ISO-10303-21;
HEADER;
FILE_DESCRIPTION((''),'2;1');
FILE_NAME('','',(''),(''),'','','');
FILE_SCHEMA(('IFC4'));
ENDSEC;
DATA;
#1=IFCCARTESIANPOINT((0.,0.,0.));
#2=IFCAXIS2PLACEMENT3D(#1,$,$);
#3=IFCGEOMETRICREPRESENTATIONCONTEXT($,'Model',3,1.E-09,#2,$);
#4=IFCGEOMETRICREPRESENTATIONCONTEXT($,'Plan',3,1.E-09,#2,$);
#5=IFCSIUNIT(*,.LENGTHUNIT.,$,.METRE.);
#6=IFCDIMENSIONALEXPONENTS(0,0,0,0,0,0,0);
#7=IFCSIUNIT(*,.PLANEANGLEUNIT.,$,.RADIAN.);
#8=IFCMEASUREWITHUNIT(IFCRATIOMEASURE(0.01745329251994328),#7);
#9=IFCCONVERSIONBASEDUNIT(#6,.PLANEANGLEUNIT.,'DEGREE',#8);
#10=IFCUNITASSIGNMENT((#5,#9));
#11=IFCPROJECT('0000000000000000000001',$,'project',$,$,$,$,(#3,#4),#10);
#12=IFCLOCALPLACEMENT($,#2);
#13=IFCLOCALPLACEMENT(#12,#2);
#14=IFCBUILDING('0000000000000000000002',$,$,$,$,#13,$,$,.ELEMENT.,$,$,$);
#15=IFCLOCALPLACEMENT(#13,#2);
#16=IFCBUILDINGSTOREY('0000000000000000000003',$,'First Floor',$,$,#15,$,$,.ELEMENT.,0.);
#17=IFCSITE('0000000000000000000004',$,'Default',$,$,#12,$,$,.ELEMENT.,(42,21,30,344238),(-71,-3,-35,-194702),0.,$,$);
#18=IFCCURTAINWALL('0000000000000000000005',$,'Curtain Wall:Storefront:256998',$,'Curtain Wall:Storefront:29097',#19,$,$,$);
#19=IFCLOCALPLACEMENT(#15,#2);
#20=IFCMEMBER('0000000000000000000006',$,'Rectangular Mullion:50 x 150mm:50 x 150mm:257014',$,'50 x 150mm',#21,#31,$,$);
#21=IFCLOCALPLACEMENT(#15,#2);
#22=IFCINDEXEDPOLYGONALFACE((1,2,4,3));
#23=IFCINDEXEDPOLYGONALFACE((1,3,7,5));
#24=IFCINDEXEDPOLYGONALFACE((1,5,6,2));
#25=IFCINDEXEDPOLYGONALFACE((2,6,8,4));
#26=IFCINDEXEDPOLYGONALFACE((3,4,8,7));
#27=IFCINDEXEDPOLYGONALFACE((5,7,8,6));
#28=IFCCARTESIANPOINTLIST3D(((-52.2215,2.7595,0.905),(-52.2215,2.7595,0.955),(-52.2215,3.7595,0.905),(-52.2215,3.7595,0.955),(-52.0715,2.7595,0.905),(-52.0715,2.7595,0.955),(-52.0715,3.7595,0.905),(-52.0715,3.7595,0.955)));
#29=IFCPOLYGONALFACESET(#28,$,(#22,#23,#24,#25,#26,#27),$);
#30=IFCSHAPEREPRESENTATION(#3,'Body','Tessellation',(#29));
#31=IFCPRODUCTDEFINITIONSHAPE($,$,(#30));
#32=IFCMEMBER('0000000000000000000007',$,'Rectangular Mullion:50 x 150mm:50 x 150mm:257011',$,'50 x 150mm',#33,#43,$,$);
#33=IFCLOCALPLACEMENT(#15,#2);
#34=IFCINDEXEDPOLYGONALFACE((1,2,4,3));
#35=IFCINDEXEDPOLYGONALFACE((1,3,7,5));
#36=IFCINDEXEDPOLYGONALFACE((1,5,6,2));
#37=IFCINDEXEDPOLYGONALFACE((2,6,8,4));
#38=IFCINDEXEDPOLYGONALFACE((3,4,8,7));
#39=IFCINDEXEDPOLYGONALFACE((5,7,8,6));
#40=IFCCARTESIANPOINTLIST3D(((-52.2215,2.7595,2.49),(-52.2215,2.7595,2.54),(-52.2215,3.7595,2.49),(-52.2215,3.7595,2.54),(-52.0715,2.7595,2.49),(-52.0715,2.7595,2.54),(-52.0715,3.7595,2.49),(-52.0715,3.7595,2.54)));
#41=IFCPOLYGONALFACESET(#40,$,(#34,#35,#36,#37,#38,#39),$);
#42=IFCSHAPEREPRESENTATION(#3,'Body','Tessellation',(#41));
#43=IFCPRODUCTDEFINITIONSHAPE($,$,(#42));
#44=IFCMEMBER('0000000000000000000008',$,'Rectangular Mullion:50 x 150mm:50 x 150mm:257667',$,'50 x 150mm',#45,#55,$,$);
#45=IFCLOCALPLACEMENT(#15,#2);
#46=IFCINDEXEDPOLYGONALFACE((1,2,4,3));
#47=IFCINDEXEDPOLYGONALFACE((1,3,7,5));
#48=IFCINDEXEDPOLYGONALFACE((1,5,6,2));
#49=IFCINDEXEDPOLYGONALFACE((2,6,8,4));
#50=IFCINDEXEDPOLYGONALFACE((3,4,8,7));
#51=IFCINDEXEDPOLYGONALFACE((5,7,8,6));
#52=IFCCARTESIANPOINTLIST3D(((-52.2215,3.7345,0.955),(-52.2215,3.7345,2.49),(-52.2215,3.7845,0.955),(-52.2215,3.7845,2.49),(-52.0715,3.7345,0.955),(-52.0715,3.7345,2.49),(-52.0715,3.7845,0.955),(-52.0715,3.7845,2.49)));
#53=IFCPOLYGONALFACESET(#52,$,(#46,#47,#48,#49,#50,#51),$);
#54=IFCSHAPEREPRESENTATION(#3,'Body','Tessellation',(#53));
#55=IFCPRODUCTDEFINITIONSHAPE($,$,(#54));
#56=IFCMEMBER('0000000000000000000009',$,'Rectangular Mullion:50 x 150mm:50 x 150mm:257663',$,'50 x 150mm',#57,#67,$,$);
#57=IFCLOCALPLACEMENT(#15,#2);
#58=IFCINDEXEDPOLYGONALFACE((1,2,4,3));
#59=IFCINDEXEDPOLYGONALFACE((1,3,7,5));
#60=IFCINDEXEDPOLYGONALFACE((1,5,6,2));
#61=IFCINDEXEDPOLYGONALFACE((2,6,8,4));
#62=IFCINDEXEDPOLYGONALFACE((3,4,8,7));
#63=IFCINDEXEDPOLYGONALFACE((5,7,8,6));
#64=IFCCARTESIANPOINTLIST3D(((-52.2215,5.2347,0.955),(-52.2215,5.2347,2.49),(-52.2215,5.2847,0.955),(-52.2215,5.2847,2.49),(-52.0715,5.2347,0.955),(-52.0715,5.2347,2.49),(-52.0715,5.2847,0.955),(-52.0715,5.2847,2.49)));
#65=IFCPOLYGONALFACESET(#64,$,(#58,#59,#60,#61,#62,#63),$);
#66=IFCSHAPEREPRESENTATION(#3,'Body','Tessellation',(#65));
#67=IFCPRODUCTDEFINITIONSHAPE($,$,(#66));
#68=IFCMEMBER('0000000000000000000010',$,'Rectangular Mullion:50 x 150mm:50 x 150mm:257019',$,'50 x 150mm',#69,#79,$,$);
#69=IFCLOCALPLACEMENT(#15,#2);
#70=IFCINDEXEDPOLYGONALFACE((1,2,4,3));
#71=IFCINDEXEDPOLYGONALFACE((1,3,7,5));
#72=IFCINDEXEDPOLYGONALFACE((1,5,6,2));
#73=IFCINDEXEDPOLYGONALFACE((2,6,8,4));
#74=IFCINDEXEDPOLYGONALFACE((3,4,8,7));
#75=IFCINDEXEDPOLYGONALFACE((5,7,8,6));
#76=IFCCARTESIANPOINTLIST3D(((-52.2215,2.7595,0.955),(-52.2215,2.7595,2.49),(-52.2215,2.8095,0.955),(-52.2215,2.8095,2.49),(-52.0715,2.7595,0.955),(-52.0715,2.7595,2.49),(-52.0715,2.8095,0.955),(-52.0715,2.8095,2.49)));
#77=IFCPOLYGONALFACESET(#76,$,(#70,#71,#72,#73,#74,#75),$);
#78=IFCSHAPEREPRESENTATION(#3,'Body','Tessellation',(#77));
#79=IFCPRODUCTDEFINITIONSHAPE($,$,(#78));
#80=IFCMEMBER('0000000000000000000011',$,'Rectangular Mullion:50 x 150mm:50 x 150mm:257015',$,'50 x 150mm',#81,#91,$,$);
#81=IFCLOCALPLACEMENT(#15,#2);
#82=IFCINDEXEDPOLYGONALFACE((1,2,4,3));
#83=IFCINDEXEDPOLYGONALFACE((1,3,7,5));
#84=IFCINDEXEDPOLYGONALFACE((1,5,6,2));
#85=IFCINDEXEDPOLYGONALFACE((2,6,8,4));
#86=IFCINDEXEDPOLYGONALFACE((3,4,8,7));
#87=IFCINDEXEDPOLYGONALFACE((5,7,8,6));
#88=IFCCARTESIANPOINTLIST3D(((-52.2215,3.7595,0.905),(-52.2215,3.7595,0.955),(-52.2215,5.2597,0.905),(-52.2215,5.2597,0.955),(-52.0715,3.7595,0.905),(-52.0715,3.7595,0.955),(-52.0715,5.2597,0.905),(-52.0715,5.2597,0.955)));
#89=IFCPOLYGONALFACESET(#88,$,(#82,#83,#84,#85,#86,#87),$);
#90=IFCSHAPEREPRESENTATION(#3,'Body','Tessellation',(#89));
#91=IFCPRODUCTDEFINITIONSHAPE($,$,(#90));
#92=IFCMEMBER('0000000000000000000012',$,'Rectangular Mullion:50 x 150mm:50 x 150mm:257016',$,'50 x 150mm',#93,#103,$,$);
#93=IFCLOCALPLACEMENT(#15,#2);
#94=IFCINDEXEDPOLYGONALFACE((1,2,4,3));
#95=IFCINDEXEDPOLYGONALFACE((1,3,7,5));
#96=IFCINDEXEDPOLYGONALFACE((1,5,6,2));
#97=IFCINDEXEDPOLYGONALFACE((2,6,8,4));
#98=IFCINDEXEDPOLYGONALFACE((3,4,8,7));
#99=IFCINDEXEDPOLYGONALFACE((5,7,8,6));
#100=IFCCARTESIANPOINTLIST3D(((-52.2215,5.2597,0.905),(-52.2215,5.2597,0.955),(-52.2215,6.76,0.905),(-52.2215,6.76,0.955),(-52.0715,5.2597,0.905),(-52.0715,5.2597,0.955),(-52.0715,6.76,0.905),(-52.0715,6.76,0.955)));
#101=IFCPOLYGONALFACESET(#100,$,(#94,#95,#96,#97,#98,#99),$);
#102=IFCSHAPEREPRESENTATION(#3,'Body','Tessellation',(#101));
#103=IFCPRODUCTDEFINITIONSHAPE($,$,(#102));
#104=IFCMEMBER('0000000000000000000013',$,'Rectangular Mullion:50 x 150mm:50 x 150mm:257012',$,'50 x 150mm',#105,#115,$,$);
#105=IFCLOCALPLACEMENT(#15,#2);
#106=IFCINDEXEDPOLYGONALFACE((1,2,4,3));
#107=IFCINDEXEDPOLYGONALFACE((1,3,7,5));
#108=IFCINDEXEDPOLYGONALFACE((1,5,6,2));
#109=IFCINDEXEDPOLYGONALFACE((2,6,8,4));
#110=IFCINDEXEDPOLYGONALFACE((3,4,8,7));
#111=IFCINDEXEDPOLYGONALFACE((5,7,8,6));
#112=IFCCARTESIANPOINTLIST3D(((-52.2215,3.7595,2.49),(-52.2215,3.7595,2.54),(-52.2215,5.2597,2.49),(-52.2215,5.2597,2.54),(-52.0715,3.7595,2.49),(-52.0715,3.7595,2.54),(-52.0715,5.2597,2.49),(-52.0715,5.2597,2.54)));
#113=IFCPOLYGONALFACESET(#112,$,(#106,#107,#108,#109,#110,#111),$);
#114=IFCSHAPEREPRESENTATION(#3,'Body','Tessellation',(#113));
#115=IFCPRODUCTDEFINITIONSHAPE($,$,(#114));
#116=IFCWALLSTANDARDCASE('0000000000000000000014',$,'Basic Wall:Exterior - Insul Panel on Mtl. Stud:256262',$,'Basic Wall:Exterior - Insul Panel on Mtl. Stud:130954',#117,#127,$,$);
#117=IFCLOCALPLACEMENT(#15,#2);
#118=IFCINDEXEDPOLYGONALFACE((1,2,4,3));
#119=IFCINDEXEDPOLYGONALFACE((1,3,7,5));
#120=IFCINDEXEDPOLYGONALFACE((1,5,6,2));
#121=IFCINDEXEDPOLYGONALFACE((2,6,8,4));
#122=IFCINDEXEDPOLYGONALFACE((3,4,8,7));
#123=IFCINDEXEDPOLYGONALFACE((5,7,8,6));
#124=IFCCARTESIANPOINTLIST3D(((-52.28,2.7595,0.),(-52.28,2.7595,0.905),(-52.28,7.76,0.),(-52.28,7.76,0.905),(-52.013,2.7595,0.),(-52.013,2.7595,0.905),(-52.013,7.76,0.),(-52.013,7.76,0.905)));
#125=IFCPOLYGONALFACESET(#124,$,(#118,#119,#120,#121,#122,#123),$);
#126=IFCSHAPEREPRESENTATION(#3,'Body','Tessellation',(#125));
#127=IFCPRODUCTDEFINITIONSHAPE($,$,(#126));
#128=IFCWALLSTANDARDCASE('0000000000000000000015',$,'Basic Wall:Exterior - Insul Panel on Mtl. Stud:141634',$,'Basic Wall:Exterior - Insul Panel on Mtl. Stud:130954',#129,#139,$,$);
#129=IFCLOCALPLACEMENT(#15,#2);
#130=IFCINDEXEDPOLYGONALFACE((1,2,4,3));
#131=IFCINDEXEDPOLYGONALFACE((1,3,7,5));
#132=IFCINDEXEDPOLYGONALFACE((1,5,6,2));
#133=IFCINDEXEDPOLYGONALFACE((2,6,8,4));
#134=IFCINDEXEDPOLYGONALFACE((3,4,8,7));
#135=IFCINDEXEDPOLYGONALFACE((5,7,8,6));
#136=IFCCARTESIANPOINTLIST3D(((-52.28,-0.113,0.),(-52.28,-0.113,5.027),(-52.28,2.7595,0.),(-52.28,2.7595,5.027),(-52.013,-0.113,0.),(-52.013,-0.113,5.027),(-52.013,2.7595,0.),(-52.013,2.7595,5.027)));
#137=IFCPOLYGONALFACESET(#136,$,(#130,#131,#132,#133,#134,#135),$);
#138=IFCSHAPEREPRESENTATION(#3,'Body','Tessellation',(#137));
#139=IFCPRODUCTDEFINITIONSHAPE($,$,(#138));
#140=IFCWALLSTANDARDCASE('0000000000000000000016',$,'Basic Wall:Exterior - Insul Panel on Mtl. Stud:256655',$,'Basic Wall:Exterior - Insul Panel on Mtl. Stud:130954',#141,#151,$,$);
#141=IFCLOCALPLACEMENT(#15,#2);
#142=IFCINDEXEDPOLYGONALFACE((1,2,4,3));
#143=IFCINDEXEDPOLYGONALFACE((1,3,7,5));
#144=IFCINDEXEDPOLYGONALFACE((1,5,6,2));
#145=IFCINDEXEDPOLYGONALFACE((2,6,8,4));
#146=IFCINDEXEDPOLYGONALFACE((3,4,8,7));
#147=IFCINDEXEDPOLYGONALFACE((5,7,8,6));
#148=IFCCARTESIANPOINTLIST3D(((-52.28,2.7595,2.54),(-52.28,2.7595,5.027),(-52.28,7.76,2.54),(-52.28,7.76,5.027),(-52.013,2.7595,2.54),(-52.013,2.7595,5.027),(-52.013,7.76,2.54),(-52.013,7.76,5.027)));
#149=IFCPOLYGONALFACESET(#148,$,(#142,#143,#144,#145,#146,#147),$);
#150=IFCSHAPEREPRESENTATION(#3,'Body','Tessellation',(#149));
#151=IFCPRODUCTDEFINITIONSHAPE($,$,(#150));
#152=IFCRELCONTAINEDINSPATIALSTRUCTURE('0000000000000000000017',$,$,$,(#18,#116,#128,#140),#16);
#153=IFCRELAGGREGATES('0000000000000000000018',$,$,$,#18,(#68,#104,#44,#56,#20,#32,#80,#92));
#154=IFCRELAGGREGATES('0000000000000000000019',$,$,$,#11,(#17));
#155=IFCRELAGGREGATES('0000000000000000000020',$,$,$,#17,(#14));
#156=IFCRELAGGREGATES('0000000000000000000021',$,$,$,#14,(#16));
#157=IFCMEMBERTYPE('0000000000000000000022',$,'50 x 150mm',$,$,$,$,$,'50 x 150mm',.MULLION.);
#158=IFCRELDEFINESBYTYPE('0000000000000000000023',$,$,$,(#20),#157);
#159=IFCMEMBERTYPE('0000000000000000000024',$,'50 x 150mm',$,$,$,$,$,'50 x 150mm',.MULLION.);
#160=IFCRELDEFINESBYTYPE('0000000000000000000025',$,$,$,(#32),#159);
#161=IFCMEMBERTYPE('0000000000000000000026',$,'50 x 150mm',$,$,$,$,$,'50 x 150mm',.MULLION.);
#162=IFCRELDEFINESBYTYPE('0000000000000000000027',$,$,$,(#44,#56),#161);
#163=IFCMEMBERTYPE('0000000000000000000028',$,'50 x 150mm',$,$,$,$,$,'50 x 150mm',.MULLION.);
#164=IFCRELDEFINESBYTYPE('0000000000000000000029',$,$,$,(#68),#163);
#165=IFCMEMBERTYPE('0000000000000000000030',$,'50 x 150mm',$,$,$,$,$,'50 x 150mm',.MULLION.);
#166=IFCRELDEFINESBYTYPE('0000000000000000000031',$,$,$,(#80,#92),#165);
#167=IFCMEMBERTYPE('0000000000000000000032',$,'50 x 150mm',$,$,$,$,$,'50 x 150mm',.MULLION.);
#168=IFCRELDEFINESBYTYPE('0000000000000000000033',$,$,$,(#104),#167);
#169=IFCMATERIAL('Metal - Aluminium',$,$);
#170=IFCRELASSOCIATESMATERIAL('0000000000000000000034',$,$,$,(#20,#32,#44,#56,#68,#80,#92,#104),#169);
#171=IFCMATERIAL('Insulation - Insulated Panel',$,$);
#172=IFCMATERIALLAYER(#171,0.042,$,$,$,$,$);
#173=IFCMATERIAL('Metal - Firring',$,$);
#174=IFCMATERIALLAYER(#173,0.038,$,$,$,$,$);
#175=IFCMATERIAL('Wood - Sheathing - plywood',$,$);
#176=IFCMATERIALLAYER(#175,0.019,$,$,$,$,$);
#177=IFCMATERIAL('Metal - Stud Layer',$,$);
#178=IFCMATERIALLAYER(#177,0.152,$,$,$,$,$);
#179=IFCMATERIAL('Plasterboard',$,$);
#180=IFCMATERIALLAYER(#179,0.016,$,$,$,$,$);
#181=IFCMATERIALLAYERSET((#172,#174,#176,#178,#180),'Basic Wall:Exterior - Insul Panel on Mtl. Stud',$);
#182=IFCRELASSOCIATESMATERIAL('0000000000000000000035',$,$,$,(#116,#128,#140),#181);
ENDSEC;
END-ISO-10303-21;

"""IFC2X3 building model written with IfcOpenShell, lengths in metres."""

from ifc_helpers import new_model, entity, si_unit, converted_unit, frame, frame_2d, origin, origin_2d_with_axis, place, context, project, spatial, rectangle, extrude, source, transform, mapped, material, layer, layer_set, layer_usage, type_object, type_shapes, element, aggregate, save


model = new_model("IFC2X3")

# Units and contexts
model_context = context("Model", 3, precision=1e-09, world=origin())
plan_context = context("Plan", 3, precision=1e-09, world=origin())
ifc_project = project(units=[si_unit("LENGTHUNIT", "METRE"), converted_unit("PLANEANGLEUNIT", "DEGREE", entity("IfcRatioMeasure", 0.01745329251994328), si_unit("PLANEANGLEUNIT", "RADIAN"), dimensions=[0, 0, 0, 0, 0, 0, 0])], contexts=[model_context, plan_context])

# Site, building, storey
site_placement = place(None, origin())
site = spatial("IfcSite", under=ifc_project, at=site_placement, Name="Default", CompositionType="ELEMENT", RefLatitude=(42, 21, 30, 344238), RefLongitude=(-71, -3, -35, -194702), RefElevation=0.0)
building_placement = place(site_placement, origin())
building = spatial("IfcBuilding", under=site, at=building_placement, CompositionType="ELEMENT")
storey_placement = place(building_placement, origin())
storey = spatial("IfcBuildingStorey", under=building, at=storey_placement, Name="First Floor", CompositionType="ELEMENT", Elevation=0.0)

# Curtain wall, members
curtain_wall_placement = place(storey_placement, origin())
curtain_wall = element("IfcCurtainWall", 1, at=curtain_wall_placement, inside=storey, Name="Curtain Wall:Storefront:256998", ObjectType="Curtain Wall:Storefront:29097")
ifc_material_1 = material(Name="Metal - Aluminium")
member_type_1 = type_object("IfcMemberType", Name="50 x 150mm", ElementType="50 x 150mm", PredefinedType="MULLION")
shared_shape_1 = source(origin(), model_context, "Body", "SweptSolid", [
    extrude(rectangle(XDim=0.05, YDim=0.15, at=origin_2d_with_axis()), frame((-0.025, 0.0, -1.0), z_axis=(0.0, 0.0, 1.0), x_axis=(-1.0, 0.0, 0.0)), (0.0, 0.0, 1.0), 1.0),
])
type_shapes(member_type_1, [shared_shape_1])
member_1_placement = place(storey_placement, frame((-52.1465, 2.7595, 0.905), z_axis=(0.0, -1.0, 0.0), x_axis=(0.0, 0.0, -1.0)))
member_1 = element("IfcMember", 2, at=member_1_placement, type_object=member_type_1, material=ifc_material_1, Name="Rectangular Mullion:50 x 150mm:50 x 150mm:257014", ObjectType="50 x 150mm", context=model_context, shape_type="MappedRepresentation", body=[
    mapped(shared_shape_1, transform((0.0, 0.0, 0.0), scale=1.0)),
])
member_type_2 = type_object("IfcMemberType", Name="50 x 150mm", ElementType="50 x 150mm", PredefinedType="MULLION")
type_shapes(member_type_2, [shared_shape_1])
member_2_placement = place(storey_placement, frame((-52.1465, 3.7595, 2.54), z_axis=(0.0, 1.0, 0.0), x_axis=(0.0, 0.0, 1.0)))
member_2 = element("IfcMember", 3, at=member_2_placement, type_object=member_type_2, material=ifc_material_1, Name="Rectangular Mullion:50 x 150mm:50 x 150mm:257011", ObjectType="50 x 150mm", context=model_context, shape_type="MappedRepresentation", body=[
    mapped(shared_shape_1, transform((0.0, 0.0, 0.0), scale=1.0)),
])
member_type_3 = type_object("IfcMemberType", Name="50 x 150mm", ElementType="50 x 150mm", PredefinedType="MULLION")
shared_shape_2 = source(origin(), model_context, "Body", "SweptSolid", [
    extrude(rectangle(XDim=0.05, YDim=0.15, at=origin_2d_with_axis()), frame((0.0, 0.0, -1.535), z_axis=(0.0, 0.0, 1.0), x_axis=(-1.0, 0.0, 0.0)), (0.0, 0.0, 1.0), 1.535),
])
type_shapes(member_type_3, [shared_shape_2])
member_3_placement = place(storey_placement, frame((-52.1465, 3.7595, 0.955), z_axis=(0.0, 0.0, -1.0), x_axis=(0.0, 1.0, 0.0)))
member_3 = element("IfcMember", 4, at=member_3_placement, type_object=member_type_3, material=ifc_material_1, Name="Rectangular Mullion:50 x 150mm:50 x 150mm:257667", ObjectType="50 x 150mm", context=model_context, shape_type="MappedRepresentation", body=[
    mapped(shared_shape_2, transform((0.0, 0.0, 0.0), scale=1.0)),
])
member_4_placement = place(storey_placement, frame((-52.1465, 5.2597, 0.955), z_axis=(0.0, 0.0, -1.0), x_axis=(0.0, 1.0, 0.0)))
member_4 = element("IfcMember", 5, at=member_4_placement, type_object=member_type_3, material=ifc_material_1, Name="Rectangular Mullion:50 x 150mm:50 x 150mm:257663", ObjectType="50 x 150mm", context=model_context, shape_type="MappedRepresentation", body=[
    mapped(shared_shape_2, transform((0.0, 0.0, 0.0), scale=1.0)),
])
member_type_4 = type_object("IfcMemberType", Name="50 x 150mm", ElementType="50 x 150mm", PredefinedType="MULLION")
shared_shape_3 = source(origin(), model_context, "Body", "SweptSolid", [
    extrude(rectangle(XDim=0.05, YDim=0.15, at=origin_2d_with_axis()), frame((-0.025, 0.0, -1.535), z_axis=(0.0, 0.0, 1.0), x_axis=(-1.0, 0.0, 0.0)), (0.0, 0.0, 1.0), 1.535),
])
type_shapes(member_type_4, [shared_shape_3])
member_5_placement = place(storey_placement, frame((-52.1465, 2.7595, 2.49), z_axis=(0.0, 0.0, 1.0), x_axis=(0.0, -1.0, 0.0)))
member_5 = element("IfcMember", 6, at=member_5_placement, type_object=member_type_4, material=ifc_material_1, Name="Rectangular Mullion:50 x 150mm:50 x 150mm:257019", ObjectType="50 x 150mm", context=model_context, shape_type="MappedRepresentation", body=[
    mapped(shared_shape_3, transform((0.0, 0.0, 0.0), scale=1.0)),
])
member_type_5 = type_object("IfcMemberType", Name="50 x 150mm", ElementType="50 x 150mm", PredefinedType="MULLION")
shared_shape_4 = source(origin(), model_context, "Body", "SweptSolid", [
    extrude(rectangle(XDim=0.05, YDim=0.15, at=origin_2d_with_axis()), frame((-0.025, 0.0, -1.5003), z_axis=(0.0, 0.0, 1.0), x_axis=(-1.0, 0.0, 0.0)), (0.0, 0.0, 1.0), 1.5003),
])
type_shapes(member_type_5, [shared_shape_4])
member_6_placement = place(storey_placement, frame((-52.1465, 3.7595, 0.905), z_axis=(0.0, -1.0, 0.0), x_axis=(0.0, 0.0, -1.0)))
member_6 = element("IfcMember", 7, at=member_6_placement, type_object=member_type_5, material=ifc_material_1, Name="Rectangular Mullion:50 x 150mm:50 x 150mm:257015", ObjectType="50 x 150mm", context=model_context, shape_type="MappedRepresentation", body=[
    mapped(shared_shape_4, transform((0.0, 0.0, 0.0), scale=1.0)),
])
member_7_placement = place(storey_placement, frame((-52.1465, 5.2597, 0.905), z_axis=(0.0, -1.0, 0.0), x_axis=(0.0, 0.0, -1.0)))
member_7 = element("IfcMember", 8, at=member_7_placement, type_object=member_type_5, material=ifc_material_1, Name="Rectangular Mullion:50 x 150mm:50 x 150mm:257016", ObjectType="50 x 150mm", context=model_context, shape_type="MappedRepresentation", body=[
    mapped(shared_shape_4, transform((0.0, 0.0, 0.0), scale=1.0)),
])
member_type_6 = type_object("IfcMemberType", Name="50 x 150mm", ElementType="50 x 150mm", PredefinedType="MULLION")
shared_shape_5 = source(origin(), model_context, "Body", "SweptSolid", [
    extrude(rectangle(XDim=0.05, YDim=0.15, at=origin_2d_with_axis()), frame((-0.025, 0.0, -1.5003), z_axis=(0.0, 0.0, 1.0), x_axis=(-1.0, 0.0, 0.0)), (0.0, 0.0, 1.0), 1.5003),
])
type_shapes(member_type_6, [shared_shape_5])
member_8_placement = place(storey_placement, frame((-52.1465, 5.2597, 2.54), z_axis=(0.0, 1.0, 0.0), x_axis=(0.0, 0.0, 1.0)))
member_8 = element("IfcMember", 9, at=member_8_placement, type_object=member_type_6, material=ifc_material_1, Name="Rectangular Mullion:50 x 150mm:50 x 150mm:257012", ObjectType="50 x 150mm", context=model_context, shape_type="MappedRepresentation", body=[
    mapped(shared_shape_5, transform((0.0, 0.0, 0.0), scale=1.0)),
])
aggregate(curtain_wall, [member_5, member_8, member_3, member_4, member_1, member_2, member_6, member_7])

# Walls
ifc_material_2 = material(Name="Insulation - Insulated Panel")
ifc_layer_1 = layer(ifc_material_2, 0.042)
ifc_material_3 = material(Name="Metal - Firring")
ifc_layer_2 = layer(ifc_material_3, 0.038)
ifc_material_4 = material(Name="Wood - Sheathing - plywood")
ifc_layer_3 = layer(ifc_material_4, 0.019)
ifc_material_5 = material(Name="Metal - Stud Layer")
ifc_layer_4 = layer(ifc_material_5, 0.152)
ifc_material_6 = material(Name="Plasterboard")
ifc_layer_5 = layer(ifc_material_6, 0.016)
ifc_layer_set = layer_set([ifc_layer_1, ifc_layer_2, ifc_layer_3, ifc_layer_4, ifc_layer_5], Name="Basic Wall:Exterior - Insul Panel on Mtl. Stud")
ifc_layer_usage = layer_usage(ifc_layer_set, "AXIS2", "NEGATIVE", 0.1335)
wall_1_placement = place(storey_placement, frame((-52.1465, 2.7595, 0.0), z_axis=(0.0, 0.0, 1.0), x_axis=(0.0, 1.0, 0.0)))
element("IfcWallStandardCase", 10, at=wall_1_placement, inside=storey, material=ifc_layer_usage, Name="Basic Wall:Exterior - Insul Panel on Mtl. Stud:256262", ObjectType="Basic Wall:Exterior - Insul Panel on Mtl. Stud:130954", context=model_context, shape_type="SweptSolid", body=[
    extrude(rectangle(XDim=5.0005, YDim=0.267, at=frame_2d((2.5003, 0.0), x_axis=(-1.0, 0.0))), origin(), (0.0, 0.0, 1.0), 0.905),
])
wall_2_placement = place(storey_placement, frame((-52.1465, -0.113, 0.0), z_axis=(0.0, 0.0, 1.0), x_axis=(0.0, 1.0, 0.0)))
element("IfcWallStandardCase", 11, at=wall_2_placement, inside=storey, material=ifc_layer_usage, Name="Basic Wall:Exterior - Insul Panel on Mtl. Stud:141634", ObjectType="Basic Wall:Exterior - Insul Panel on Mtl. Stud:130954", context=model_context, shape_type="SweptSolid", body=[
    extrude(rectangle(XDim=2.8725, YDim=0.267, at=frame_2d((1.4362, 0.0), x_axis=(-1.0, 0.0))), origin(), (0.0, 0.0, 1.0), 5.027),
])
wall_3_placement = place(storey_placement, frame((-52.1465, 2.7595, 2.54), z_axis=(0.0, 0.0, 1.0), x_axis=(0.0, 1.0, 0.0)))
element("IfcWallStandardCase", 12, at=wall_3_placement, inside=storey, material=ifc_layer_usage, Name="Basic Wall:Exterior - Insul Panel on Mtl. Stud:256655", ObjectType="Basic Wall:Exterior - Insul Panel on Mtl. Stud:130954", context=model_context, shape_type="SweptSolid", body=[
    extrude(rectangle(XDim=5.0005, YDim=0.267, at=frame_2d((2.5003, 0.0), x_axis=(-1.0, 0.0))), origin(), (0.0, 0.0, 1.0), 2.487),
])

save(model, "model.ifc")
